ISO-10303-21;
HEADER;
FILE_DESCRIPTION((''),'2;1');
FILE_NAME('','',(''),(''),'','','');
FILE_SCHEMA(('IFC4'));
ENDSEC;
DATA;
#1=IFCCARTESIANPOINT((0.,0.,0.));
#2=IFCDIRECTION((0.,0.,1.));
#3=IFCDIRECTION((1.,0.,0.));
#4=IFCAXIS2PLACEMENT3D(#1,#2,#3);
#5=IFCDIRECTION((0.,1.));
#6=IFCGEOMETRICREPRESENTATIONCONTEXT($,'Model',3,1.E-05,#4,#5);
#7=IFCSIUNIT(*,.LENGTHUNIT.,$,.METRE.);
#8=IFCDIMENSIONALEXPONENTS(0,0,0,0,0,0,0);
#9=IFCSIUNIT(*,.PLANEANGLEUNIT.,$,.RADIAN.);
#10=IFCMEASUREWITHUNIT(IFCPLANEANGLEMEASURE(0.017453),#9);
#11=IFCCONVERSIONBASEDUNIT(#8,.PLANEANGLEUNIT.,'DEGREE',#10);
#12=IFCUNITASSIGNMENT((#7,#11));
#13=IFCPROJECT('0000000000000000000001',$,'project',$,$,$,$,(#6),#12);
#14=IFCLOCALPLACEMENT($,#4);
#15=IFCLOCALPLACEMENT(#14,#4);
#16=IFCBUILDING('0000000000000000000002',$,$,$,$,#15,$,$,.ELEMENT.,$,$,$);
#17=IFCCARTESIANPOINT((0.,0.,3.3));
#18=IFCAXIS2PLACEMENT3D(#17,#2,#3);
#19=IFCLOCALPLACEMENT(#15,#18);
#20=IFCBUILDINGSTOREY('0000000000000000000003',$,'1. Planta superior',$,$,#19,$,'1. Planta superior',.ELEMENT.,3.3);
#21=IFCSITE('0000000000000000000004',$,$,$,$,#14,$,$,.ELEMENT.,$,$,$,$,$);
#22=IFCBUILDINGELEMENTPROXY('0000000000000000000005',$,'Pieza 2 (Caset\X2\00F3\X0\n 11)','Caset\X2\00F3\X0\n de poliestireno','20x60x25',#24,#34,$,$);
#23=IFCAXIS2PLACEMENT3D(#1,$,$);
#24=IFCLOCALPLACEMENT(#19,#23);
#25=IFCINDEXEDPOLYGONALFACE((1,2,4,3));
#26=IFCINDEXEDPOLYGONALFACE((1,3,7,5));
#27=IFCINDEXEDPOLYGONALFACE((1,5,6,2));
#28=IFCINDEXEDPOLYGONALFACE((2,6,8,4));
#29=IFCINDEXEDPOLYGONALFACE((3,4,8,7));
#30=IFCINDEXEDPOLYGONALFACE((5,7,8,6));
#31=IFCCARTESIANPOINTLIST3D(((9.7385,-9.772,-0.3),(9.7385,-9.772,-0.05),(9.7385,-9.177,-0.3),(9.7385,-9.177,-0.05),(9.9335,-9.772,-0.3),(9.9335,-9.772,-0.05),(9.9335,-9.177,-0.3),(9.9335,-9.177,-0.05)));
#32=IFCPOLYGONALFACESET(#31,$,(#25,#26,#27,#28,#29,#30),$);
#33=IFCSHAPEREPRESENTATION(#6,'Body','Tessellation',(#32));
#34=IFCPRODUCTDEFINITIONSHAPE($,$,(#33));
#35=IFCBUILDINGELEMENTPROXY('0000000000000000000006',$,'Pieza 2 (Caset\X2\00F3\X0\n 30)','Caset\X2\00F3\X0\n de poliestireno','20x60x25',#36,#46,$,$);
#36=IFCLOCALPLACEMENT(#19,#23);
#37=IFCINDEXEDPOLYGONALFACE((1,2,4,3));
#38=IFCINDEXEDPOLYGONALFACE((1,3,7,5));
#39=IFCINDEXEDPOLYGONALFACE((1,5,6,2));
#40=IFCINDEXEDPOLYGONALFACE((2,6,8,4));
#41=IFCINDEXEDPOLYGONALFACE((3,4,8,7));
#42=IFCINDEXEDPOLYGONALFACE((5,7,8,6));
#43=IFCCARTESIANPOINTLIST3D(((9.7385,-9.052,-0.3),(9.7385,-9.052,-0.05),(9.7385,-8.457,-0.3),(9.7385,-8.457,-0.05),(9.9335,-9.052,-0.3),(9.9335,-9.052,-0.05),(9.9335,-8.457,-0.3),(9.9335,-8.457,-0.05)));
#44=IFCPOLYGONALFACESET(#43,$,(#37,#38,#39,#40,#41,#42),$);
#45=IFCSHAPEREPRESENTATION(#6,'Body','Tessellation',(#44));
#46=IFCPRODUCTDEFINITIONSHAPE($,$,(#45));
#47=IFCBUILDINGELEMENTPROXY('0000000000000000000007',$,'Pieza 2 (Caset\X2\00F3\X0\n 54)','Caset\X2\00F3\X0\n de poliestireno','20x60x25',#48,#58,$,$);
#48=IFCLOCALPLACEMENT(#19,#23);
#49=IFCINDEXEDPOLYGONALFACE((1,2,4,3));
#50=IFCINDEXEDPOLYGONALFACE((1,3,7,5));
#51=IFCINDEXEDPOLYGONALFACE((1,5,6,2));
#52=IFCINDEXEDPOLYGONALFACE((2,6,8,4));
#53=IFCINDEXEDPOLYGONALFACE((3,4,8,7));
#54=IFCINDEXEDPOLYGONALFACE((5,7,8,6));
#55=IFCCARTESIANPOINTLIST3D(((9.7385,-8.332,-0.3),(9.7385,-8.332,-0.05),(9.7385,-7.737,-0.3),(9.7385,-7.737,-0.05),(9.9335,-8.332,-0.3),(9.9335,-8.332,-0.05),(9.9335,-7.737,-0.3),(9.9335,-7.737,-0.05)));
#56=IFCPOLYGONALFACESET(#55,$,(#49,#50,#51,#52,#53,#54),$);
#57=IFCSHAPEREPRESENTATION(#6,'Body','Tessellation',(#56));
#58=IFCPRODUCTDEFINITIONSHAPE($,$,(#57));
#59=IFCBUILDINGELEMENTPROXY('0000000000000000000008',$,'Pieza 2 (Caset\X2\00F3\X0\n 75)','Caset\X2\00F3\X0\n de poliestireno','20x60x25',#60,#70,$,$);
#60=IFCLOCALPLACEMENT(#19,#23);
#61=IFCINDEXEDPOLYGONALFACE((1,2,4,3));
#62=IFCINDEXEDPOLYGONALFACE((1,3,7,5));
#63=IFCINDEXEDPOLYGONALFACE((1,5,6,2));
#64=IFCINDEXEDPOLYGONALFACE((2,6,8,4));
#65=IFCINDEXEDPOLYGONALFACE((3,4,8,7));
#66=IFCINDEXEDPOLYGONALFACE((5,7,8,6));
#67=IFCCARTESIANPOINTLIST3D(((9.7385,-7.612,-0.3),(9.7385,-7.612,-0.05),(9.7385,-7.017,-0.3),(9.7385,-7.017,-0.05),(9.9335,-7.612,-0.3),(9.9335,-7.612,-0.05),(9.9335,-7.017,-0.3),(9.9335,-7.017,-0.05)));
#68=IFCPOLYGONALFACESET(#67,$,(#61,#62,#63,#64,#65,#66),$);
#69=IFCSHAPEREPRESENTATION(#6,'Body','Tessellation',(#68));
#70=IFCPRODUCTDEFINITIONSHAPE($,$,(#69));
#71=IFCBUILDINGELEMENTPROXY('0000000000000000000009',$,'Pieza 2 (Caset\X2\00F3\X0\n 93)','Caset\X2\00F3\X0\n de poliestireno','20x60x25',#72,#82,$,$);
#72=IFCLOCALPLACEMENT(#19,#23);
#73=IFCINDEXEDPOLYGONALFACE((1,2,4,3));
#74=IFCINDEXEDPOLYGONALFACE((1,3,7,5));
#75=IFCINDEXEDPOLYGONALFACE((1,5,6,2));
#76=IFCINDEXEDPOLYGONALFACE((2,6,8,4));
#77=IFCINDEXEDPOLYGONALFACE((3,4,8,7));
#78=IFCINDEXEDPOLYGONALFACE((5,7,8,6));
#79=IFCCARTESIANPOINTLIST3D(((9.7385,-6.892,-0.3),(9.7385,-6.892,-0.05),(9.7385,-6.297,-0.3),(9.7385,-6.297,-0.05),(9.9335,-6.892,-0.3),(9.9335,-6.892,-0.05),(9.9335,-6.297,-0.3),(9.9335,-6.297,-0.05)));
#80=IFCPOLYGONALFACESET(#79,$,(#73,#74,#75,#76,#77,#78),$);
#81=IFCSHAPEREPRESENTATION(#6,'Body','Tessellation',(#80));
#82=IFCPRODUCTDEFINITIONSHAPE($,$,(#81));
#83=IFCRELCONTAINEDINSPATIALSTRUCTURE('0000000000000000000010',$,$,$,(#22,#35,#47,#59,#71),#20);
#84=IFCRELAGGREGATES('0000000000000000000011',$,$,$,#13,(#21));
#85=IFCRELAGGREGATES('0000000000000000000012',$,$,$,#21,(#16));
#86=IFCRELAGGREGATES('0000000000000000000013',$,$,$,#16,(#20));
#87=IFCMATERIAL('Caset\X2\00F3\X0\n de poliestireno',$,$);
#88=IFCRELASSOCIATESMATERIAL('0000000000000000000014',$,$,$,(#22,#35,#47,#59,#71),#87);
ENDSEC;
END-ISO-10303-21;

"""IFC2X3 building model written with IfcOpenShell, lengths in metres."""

from ifc_helpers import new_model, entity, si_unit, converted_unit, direction, frame, origin_with_axes, origin_2d_with_axis, place, context, project, spatial, rectangle, extrude, source, transform, mapped, material, element, save


model = new_model("IFC2X3")

# Units and contexts
model_context = context("Model", 3, precision=1e-05, world=origin_with_axes(), true_north=direction((0.0, 1.0)))
ifc_project = project(units=[si_unit("LENGTHUNIT", "METRE"), converted_unit("PLANEANGLEUNIT", "DEGREE", entity("IfcPlaneAngleMeasure", 0.017453), si_unit("PLANEANGLEUNIT", "RADIAN"), dimensions=[0, 0, 0, 0, 0, 0, 0])], contexts=[model_context])

# Site, building, storey
site_placement = place(None, origin_with_axes())
site = spatial("IfcSite", under=ifc_project, at=site_placement, CompositionType="ELEMENT")
building_placement = place(site_placement, origin_with_axes())
building = spatial("IfcBuilding", under=site, at=building_placement, CompositionType="ELEMENT")
storey_placement = place(building_placement, frame((0.0, 0.0, 3.3), z_axis=(0.0, 0.0, 1.0), x_axis=(1.0, 0.0, 0.0)))
storey = spatial("IfcBuildingStorey", under=building, at=storey_placement, Name="1. Planta superior", LongName="1. Planta superior", CompositionType="ELEMENT", Elevation=3.3)

# Building element proxies
ifc_material = material(Name="Casetón de poliestireno")
shared_shape = source(origin_with_axes(), model_context, "Body", "SweptSolid", [
    extrude(rectangle(XDim=0.195, YDim=0.25, at=origin_2d_with_axis()), origin_with_axes(), (0.0, 0.0, 1.0), 0.595),
])
placement_1 = place(storey_placement, frame((9.836, -9.772, -0.175), z_axis=(0.0, 1.0, 0.0), x_axis=(-1.0, 0.0, 0.0)))
for number, where, z_axis, x_axis, name in (
    (1, (0.0, 0.0, 0.0), (0.0, 0.0, 1.0), (1.0, 0.0, 0.0), "Pieza 2 (Casetón 11)"),
):
    element("IfcBuildingElementProxy", number, at=place(placement_1, frame(where, z_axis=z_axis, x_axis=x_axis)), inside=storey, material=ifc_material, Name=name, Description="Casetón de poliestireno", ObjectType="20x60x25", context=model_context, shape_type="MappedRepresentation", body=[
        mapped(shared_shape, transform((0.0, 0.0, 0.0), x_axis=(1.0, 0.0, 0.0), y_axis=(0.0, 1.0, 0.0), z_axis=(0.0, 0.0, 1.0))),
    ])
placement_2 = place(storey_placement, frame((9.836, -9.052, -0.175), z_axis=(0.0, 1.0, 0.0), x_axis=(-1.0, 0.0, 0.0)))
for number, where, z_axis, x_axis, name in (
    (2, (0.0, 0.0, 0.0), (0.0, 0.0, 1.0), (1.0, 0.0, 0.0), "Pieza 2 (Casetón 30)"),
):
    element("IfcBuildingElementProxy", number, at=place(placement_2, frame(where, z_axis=z_axis, x_axis=x_axis)), inside=storey, material=ifc_material, Name=name, Description="Casetón de poliestireno", ObjectType="20x60x25", context=model_context, shape_type="MappedRepresentation", body=[
        mapped(shared_shape, transform((0.0, 0.0, 0.0), x_axis=(1.0, 0.0, 0.0), y_axis=(0.0, 1.0, 0.0), z_axis=(0.0, 0.0, 1.0))),
    ])
placement_3 = place(storey_placement, frame((9.836, -8.332, -0.175), z_axis=(0.0, 1.0, 0.0), x_axis=(-1.0, 0.0, 0.0)))
for number, where, z_axis, x_axis, name in (
    (3, (0.0, 0.0, 0.0), (0.0, 0.0, 1.0), (1.0, 0.0, 0.0), "Pieza 2 (Casetón 54)"),
):
    element("IfcBuildingElementProxy", number, at=place(placement_3, frame(where, z_axis=z_axis, x_axis=x_axis)), inside=storey, material=ifc_material, Name=name, Description="Casetón de poliestireno", ObjectType="20x60x25", context=model_context, shape_type="MappedRepresentation", body=[
        mapped(shared_shape, transform((0.0, 0.0, 0.0), x_axis=(1.0, 0.0, 0.0), y_axis=(0.0, 1.0, 0.0), z_axis=(0.0, 0.0, 1.0))),
    ])
placement_4 = place(storey_placement, frame((9.836, -7.612, -0.175), z_axis=(0.0, 1.0, 0.0), x_axis=(-1.0, 0.0, 0.0)))
for number, where, z_axis, x_axis, name in (
    (4, (0.0, 0.0, 0.0), (0.0, 0.0, 1.0), (1.0, 0.0, 0.0), "Pieza 2 (Casetón 75)"),
):
    element("IfcBuildingElementProxy", number, at=place(placement_4, frame(where, z_axis=z_axis, x_axis=x_axis)), inside=storey, material=ifc_material, Name=name, Description="Casetón de poliestireno", ObjectType="20x60x25", context=model_context, shape_type="MappedRepresentation", body=[
        mapped(shared_shape, transform((0.0, 0.0, 0.0), x_axis=(1.0, 0.0, 0.0), y_axis=(0.0, 1.0, 0.0), z_axis=(0.0, 0.0, 1.0))),
    ])
placement_5 = place(storey_placement, frame((9.836, -6.892, -0.175), z_axis=(0.0, 1.0, 0.0), x_axis=(-1.0, 0.0, 0.0)))
for number, where, z_axis, x_axis, name in (
    (5, (0.0, 0.0, 0.0), (0.0, 0.0, 1.0), (1.0, 0.0, 0.0), "Pieza 2 (Casetón 93)"),
):
    element("IfcBuildingElementProxy", number, at=place(placement_5, frame(where, z_axis=z_axis, x_axis=x_axis)), inside=storey, material=ifc_material, Name=name, Description="Casetón de poliestireno", ObjectType="20x60x25", context=model_context, shape_type="MappedRepresentation", body=[
        mapped(shared_shape, transform((0.0, 0.0, 0.0), x_axis=(1.0, 0.0, 0.0), y_axis=(0.0, 1.0, 0.0), z_axis=(0.0, 0.0, 1.0))),
    ])

save(model, "model.ifc")
